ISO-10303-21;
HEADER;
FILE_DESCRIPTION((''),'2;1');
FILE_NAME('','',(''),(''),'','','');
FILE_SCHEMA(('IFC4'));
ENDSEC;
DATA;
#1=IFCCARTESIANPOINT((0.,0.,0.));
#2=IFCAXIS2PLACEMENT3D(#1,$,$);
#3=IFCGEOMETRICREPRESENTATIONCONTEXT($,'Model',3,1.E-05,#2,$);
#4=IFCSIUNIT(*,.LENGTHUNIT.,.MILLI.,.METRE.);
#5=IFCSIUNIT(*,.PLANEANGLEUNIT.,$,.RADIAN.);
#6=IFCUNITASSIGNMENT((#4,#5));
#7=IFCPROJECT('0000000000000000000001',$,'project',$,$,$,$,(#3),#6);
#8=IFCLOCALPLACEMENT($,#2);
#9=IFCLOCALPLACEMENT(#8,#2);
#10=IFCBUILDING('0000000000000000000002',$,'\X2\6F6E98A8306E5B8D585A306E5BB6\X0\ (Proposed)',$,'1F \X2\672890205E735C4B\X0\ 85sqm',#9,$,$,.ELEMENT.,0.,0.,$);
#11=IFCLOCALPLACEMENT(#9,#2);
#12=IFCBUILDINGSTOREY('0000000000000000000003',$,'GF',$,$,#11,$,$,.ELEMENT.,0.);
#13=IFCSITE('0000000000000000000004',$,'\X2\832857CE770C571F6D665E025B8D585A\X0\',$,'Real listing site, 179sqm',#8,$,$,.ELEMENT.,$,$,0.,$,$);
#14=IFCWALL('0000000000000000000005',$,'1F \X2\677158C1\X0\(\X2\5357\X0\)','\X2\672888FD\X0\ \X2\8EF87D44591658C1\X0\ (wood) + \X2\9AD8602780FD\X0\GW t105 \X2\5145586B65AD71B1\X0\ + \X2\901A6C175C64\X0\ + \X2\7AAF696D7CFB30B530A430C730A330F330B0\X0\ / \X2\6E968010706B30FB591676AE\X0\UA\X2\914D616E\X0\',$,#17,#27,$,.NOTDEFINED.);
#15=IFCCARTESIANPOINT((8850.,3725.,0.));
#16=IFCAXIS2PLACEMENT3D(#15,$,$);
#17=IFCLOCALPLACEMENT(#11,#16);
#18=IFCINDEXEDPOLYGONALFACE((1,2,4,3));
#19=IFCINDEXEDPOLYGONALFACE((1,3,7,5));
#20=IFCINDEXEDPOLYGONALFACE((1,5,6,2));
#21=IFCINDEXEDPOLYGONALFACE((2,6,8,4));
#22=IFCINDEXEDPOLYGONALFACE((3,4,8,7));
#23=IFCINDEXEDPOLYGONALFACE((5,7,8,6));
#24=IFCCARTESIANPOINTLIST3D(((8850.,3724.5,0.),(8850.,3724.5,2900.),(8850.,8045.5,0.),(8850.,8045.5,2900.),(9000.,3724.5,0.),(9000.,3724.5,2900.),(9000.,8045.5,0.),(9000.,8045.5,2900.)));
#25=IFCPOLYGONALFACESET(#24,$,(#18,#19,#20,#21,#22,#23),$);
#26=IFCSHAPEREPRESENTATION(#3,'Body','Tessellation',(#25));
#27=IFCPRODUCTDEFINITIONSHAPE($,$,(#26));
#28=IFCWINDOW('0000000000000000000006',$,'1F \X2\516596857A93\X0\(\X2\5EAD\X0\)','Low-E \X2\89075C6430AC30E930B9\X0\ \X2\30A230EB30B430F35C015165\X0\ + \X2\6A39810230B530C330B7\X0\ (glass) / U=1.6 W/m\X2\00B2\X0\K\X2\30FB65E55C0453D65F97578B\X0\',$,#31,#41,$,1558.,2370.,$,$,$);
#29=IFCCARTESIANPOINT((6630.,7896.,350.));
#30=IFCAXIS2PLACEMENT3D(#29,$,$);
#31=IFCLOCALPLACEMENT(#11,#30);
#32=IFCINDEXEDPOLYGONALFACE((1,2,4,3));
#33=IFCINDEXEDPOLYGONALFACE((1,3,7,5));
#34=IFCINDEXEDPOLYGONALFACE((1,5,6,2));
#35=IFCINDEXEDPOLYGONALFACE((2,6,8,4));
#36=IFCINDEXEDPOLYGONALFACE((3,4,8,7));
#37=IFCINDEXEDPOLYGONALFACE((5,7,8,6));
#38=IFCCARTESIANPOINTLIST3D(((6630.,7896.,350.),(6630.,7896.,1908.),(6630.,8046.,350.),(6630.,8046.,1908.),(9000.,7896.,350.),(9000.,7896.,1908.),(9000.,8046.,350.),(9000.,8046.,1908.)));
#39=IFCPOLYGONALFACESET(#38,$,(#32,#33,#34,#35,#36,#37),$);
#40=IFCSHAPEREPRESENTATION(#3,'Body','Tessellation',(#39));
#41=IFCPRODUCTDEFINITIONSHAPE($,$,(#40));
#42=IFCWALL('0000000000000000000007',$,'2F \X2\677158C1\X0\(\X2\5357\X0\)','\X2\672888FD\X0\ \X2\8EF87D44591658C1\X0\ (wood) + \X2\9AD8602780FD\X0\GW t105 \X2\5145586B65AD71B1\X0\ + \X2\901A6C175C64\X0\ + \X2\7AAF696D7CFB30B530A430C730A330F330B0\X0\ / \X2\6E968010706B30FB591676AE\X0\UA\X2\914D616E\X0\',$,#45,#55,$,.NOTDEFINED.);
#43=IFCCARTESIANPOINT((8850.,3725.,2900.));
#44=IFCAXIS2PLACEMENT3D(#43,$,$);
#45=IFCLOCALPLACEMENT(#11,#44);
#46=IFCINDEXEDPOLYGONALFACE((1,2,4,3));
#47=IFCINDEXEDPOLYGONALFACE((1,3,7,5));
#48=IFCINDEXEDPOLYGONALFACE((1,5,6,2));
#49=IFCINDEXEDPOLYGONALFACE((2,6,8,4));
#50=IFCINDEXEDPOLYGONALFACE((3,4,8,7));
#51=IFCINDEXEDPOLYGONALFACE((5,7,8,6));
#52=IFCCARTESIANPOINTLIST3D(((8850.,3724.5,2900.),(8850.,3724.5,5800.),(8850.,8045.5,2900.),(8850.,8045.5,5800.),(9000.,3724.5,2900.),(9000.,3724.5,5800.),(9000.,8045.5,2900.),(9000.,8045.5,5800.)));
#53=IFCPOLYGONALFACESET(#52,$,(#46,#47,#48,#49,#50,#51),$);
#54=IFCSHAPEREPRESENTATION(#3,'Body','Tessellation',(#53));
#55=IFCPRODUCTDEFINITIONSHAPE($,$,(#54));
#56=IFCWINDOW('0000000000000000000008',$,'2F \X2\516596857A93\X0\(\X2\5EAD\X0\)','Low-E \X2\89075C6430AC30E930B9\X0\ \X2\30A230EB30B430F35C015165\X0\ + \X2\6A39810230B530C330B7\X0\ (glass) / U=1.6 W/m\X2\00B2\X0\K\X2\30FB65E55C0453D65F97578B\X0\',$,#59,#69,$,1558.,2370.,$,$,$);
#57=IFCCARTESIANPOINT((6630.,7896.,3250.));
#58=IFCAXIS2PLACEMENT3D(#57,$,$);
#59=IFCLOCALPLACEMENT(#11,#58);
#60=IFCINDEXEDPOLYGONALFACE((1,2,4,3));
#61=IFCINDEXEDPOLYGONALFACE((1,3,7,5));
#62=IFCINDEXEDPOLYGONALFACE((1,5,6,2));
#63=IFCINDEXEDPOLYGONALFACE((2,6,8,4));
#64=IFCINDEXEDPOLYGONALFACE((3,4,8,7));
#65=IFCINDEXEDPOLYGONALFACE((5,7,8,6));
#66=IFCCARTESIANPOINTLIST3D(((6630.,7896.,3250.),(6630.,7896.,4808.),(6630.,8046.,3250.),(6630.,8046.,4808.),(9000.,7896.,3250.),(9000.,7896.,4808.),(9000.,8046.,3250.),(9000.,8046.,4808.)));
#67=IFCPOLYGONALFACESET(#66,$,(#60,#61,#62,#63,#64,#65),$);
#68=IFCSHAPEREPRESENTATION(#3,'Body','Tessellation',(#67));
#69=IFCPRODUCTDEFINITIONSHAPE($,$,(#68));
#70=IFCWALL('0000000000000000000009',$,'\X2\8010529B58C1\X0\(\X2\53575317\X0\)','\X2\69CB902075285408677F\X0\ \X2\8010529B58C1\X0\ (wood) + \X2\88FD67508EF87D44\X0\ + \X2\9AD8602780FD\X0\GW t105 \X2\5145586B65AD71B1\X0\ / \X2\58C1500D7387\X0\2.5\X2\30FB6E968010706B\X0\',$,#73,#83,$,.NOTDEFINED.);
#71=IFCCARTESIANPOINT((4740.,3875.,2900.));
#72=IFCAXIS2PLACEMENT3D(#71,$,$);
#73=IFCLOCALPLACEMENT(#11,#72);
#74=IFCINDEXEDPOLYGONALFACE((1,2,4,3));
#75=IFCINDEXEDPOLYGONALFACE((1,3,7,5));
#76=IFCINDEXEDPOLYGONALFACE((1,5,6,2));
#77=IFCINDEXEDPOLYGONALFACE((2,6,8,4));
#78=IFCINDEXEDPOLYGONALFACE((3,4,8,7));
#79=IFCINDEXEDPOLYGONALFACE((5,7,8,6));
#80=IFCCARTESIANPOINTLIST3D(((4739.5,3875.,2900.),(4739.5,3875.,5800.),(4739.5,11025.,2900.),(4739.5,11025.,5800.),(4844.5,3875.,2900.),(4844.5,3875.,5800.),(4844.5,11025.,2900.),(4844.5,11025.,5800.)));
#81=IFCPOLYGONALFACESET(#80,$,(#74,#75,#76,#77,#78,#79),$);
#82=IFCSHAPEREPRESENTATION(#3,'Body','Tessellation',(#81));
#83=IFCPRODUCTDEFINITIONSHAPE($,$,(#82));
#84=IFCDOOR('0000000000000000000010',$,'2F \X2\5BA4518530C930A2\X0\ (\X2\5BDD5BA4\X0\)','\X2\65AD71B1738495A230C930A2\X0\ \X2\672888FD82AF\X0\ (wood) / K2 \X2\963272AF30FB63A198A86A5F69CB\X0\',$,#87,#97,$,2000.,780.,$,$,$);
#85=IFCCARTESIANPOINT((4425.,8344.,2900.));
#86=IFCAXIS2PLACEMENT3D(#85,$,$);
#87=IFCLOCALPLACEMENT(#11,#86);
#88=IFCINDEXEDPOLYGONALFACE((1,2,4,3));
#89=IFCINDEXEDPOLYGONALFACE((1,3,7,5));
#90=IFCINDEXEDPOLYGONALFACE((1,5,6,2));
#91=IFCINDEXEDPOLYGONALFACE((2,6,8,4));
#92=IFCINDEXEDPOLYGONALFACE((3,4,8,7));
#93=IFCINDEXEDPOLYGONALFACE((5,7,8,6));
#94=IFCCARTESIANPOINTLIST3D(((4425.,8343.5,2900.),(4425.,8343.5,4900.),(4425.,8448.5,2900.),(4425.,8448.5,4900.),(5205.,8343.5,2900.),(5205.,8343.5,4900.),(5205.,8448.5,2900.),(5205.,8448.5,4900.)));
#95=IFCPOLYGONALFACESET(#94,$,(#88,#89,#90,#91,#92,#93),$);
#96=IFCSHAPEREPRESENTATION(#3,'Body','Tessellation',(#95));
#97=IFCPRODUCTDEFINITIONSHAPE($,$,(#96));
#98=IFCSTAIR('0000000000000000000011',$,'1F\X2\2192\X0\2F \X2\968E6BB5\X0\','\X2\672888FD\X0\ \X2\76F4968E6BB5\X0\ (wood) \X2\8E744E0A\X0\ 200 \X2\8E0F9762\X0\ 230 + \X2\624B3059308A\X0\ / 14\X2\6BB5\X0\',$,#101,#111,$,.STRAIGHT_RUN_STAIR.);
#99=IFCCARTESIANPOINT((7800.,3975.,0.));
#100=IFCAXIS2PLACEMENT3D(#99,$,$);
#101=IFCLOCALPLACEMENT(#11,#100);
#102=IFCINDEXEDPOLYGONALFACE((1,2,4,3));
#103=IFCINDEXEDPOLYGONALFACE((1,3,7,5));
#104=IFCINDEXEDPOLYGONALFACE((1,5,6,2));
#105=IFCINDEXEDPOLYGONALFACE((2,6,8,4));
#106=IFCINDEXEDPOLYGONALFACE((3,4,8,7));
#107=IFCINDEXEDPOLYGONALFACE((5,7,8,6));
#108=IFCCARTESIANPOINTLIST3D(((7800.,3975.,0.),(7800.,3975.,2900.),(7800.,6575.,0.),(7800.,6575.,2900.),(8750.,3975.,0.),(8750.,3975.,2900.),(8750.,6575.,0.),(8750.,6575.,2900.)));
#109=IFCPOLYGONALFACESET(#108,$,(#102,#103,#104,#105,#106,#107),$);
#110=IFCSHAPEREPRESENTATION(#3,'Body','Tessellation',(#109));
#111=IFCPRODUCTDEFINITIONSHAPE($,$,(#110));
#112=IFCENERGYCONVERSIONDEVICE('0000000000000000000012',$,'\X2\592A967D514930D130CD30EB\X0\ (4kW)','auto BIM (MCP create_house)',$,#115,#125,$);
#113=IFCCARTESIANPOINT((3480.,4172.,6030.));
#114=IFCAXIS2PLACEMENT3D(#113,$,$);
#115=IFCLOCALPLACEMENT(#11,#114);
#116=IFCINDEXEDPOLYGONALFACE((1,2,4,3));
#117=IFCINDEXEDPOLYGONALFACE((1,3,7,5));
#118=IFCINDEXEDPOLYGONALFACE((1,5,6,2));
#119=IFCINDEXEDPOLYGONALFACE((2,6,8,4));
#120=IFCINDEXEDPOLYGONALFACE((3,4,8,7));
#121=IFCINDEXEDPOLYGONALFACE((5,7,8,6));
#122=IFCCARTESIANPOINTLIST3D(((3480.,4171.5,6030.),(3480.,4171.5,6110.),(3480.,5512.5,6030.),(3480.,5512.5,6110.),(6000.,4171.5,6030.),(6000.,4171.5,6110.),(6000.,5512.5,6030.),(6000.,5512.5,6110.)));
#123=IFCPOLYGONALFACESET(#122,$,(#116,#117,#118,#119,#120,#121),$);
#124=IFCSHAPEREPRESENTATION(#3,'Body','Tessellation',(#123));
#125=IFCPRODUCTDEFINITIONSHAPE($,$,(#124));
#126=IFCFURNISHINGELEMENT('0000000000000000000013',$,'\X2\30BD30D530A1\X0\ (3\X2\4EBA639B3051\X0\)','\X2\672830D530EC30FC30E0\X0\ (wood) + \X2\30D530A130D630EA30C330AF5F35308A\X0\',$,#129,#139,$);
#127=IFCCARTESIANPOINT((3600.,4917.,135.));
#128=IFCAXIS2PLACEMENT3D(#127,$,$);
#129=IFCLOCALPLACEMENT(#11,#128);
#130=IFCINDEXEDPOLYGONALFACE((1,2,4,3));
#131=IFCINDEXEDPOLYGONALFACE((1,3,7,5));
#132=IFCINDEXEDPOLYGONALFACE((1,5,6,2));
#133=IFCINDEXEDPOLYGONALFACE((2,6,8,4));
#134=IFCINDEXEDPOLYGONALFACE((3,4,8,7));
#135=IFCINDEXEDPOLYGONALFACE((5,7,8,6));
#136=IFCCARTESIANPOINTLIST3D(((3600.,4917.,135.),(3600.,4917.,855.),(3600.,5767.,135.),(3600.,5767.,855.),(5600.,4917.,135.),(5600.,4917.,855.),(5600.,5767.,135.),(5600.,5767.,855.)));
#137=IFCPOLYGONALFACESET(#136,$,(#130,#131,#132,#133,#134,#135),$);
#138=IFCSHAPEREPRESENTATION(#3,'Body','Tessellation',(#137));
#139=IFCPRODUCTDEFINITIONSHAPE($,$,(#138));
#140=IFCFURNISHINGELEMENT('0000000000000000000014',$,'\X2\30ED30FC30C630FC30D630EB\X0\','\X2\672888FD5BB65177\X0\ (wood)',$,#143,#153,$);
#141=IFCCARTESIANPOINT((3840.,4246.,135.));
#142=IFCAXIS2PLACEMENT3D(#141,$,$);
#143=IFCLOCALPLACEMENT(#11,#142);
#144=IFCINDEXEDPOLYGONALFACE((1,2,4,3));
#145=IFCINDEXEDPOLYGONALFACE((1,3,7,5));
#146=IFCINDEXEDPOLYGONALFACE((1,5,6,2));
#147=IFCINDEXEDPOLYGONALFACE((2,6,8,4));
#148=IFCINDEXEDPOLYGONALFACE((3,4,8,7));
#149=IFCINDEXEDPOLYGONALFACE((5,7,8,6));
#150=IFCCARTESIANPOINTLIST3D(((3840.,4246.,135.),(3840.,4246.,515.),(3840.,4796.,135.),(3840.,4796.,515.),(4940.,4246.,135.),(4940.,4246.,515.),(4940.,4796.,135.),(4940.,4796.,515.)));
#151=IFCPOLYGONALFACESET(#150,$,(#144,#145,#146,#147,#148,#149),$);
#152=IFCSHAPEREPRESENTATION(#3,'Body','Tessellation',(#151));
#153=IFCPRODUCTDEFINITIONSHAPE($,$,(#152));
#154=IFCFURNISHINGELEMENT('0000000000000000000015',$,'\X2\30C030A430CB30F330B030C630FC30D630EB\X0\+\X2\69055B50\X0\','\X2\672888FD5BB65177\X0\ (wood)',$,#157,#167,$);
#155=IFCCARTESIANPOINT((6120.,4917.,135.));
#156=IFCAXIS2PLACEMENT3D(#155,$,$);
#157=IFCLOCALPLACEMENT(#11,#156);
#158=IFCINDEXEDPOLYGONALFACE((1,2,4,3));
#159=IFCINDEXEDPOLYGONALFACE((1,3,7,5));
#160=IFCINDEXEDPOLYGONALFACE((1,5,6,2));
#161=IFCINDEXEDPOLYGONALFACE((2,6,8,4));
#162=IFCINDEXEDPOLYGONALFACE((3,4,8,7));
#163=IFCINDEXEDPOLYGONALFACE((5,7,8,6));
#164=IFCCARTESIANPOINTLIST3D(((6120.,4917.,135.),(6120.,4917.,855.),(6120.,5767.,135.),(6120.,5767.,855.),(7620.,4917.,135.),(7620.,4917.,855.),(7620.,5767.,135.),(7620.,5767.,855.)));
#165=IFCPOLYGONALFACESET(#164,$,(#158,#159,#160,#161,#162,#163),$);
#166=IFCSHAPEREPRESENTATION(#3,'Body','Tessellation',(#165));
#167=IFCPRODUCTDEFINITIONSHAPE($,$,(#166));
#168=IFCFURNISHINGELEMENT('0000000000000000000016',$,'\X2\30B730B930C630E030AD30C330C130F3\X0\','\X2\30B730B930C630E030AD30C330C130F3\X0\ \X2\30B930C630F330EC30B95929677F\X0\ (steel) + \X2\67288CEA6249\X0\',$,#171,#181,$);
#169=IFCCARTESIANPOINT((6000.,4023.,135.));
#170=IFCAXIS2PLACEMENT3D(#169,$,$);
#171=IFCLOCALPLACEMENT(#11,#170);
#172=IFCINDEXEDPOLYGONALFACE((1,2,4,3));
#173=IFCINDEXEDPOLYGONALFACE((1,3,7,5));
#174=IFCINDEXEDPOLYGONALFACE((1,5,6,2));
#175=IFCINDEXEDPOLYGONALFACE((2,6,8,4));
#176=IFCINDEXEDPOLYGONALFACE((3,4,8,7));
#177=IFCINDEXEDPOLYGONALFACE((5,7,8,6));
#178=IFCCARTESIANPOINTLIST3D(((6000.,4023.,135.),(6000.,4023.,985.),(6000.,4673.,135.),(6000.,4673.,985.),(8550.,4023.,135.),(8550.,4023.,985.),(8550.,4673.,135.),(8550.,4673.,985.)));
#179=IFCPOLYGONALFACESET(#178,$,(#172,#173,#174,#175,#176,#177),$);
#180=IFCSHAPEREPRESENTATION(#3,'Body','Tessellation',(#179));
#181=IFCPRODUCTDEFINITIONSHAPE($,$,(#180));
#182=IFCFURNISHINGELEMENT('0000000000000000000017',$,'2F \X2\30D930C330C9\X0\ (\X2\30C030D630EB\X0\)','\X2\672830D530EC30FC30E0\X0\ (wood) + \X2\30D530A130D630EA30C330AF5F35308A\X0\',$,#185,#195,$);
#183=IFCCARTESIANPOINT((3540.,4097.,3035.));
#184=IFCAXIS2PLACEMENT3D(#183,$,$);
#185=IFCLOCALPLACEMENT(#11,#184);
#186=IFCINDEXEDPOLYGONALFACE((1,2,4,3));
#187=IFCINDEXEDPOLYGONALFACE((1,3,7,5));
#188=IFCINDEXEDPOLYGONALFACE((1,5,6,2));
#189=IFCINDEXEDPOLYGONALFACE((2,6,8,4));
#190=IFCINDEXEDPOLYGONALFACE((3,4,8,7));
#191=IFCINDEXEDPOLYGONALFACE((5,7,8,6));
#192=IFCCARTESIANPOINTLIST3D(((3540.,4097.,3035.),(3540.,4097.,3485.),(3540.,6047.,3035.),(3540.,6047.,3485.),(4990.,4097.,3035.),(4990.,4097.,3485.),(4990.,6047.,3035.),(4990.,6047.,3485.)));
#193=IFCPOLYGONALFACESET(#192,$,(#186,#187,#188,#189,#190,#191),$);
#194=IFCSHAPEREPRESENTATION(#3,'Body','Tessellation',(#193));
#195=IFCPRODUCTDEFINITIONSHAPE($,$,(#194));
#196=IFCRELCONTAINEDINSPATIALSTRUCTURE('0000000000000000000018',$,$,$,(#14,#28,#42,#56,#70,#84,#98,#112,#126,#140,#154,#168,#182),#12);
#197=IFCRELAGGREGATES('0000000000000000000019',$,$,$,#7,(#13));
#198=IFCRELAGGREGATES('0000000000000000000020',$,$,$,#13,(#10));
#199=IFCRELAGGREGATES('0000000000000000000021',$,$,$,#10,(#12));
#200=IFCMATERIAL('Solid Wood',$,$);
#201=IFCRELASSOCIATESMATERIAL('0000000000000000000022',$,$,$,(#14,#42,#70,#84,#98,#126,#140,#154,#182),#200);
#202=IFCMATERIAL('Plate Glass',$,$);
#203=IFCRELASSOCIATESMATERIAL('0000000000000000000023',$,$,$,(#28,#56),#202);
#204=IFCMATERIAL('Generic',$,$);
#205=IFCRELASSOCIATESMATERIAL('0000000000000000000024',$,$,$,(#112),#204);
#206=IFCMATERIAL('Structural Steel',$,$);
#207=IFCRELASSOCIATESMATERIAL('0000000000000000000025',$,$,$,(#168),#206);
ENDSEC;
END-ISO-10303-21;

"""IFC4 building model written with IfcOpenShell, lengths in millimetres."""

from ifc_helpers import new_model, si_unit, frame, frame_2d, origin, place, context, project, spatial, rectangle, extrude, material, element, fill, save


model = new_model("IFC4")

# Units and contexts
model_context = context("Model", 3, precision=1e-05, world=origin())
ifc_project = project(units=[si_unit("LENGTHUNIT", "METRE", prefix="MILLI"), si_unit("PLANEANGLEUNIT", "RADIAN")], contexts=[model_context])

# Site, building, storey
site_placement = place(None, origin())
site = spatial("IfcSite", under=ifc_project, at=site_placement, Name="茨城県土浦市宍塚", ObjectType="Real listing site, 179sqm", CompositionType="ELEMENT", RefElevation=0.0)
building_placement = place(site_placement, origin())
building = spatial("IfcBuilding", under=site, at=building_placement, Name="潮風の宍塚の家 (Proposed)", ObjectType="1F 木造平屋 85sqm", CompositionType="ELEMENT", ElevationOfRefHeight=0.0, ElevationOfTerrain=0.0)
storey_placement = place(building_placement, origin())
storey = spatial("IfcBuildingStorey", under=building, at=storey_placement, Name="GF", CompositionType="ELEMENT", Elevation=0.0)

# Wall, opening, window
ifc_material_1 = material(Name="Solid Wood")
wall_1_placement = place(storey_placement, frame((8850.0, 3725.0, 0.0)))
wall_1 = element("IfcWall", 1, at=wall_1_placement, inside=storey, material=ifc_material_1, Name="1F 東壁(南)", Description="木製 軸組外壁 (wood) + 高性能GW t105 充填断熱 + 通気層 + 窯業系サイディング / 準耐火・外皮UA配慮", PredefinedType="NOTDEFINED", context=model_context, shape_type="SweptSolid", body=[
    extrude(rectangle(XDim=150.0, YDim=4321.0, at=frame_2d((75.0, 2160.0))), frame((8850.0, 3725.0, 0.0)), (0.0, 0.0, 1.0), 2900.0),
])
opening_1_placement = place(storey_placement, frame((6630.0, 7896.0, 350.0)))
opening_1 = element("IfcOpeningElement", 2, at=opening_1_placement, cuts=wall_1, PredefinedType="NOTDEFINED", context=model_context, shape_type="SweptSolid", body=[
    extrude(rectangle(XDim=2370.0, YDim=150.0, at=frame_2d((1185.0, 75.0))), frame((6630.0, 7896.0, 350.0)), (0.0, 0.0, 1.0), 1558.0),
])
ifc_material_2 = material(Name="Plate Glass")
window_1_placement = place(storey_placement, frame((6630.0, 7896.0, 350.0)))
window_1 = element("IfcWindow", 3, at=window_1_placement, inside=storey, material=ifc_material_2, Name="1F 入隅窓(庭)", Description="Low-E 複層ガラス アルゴン封入 + 樹脂サッシ (glass) / U=1.6 W/m²K・日射取得型", OverallHeight=1558.0, OverallWidth=2370.0, context=model_context, shape_type="SweptSolid", body=[
    extrude(rectangle(XDim=2370.0, YDim=150.0, at=frame_2d((1185.0, 75.0))), frame((6630.0, 7896.0, 350.0)), (0.0, 0.0, 1.0), 1558.0),
])
fill(opening_1, window_1)

# Wall, opening, window
wall_2_placement = place(storey_placement, frame((8850.0, 3725.0, 2900.0)))
wall_2 = element("IfcWall", 4, at=wall_2_placement, inside=storey, material=ifc_material_1, Name="2F 東壁(南)", Description="木製 軸組外壁 (wood) + 高性能GW t105 充填断熱 + 通気層 + 窯業系サイディング / 準耐火・外皮UA配慮", PredefinedType="NOTDEFINED", context=model_context, shape_type="SweptSolid", body=[
    extrude(rectangle(XDim=150.0, YDim=4321.0, at=frame_2d((75.0, 2160.0))), frame((8850.0, 3725.0, 2900.0)), (0.0, 0.0, 1.0), 2900.0),
])
opening_2_placement = place(storey_placement, frame((6630.0, 7896.0, 3250.0)))
opening_2 = element("IfcOpeningElement", 5, at=opening_2_placement, cuts=wall_2, PredefinedType="NOTDEFINED", context=model_context, shape_type="SweptSolid", body=[
    extrude(rectangle(XDim=2370.0, YDim=150.0, at=frame_2d((1185.0, 75.0))), frame((6630.0, 7896.0, 3250.0)), (0.0, 0.0, 1.0), 1558.0),
])
window_2_placement = place(storey_placement, frame((6630.0, 7896.0, 3250.0)))
window_2 = element("IfcWindow", 6, at=window_2_placement, inside=storey, material=ifc_material_2, Name="2F 入隅窓(庭)", Description="Low-E 複層ガラス アルゴン封入 + 樹脂サッシ (glass) / U=1.6 W/m²K・日射取得型", OverallHeight=1558.0, OverallWidth=2370.0, context=model_context, shape_type="SweptSolid", body=[
    extrude(rectangle(XDim=2370.0, YDim=150.0, at=frame_2d((1185.0, 75.0))), frame((6630.0, 7896.0, 3250.0)), (0.0, 0.0, 1.0), 1558.0),
])
fill(opening_2, window_2)

# Wall, opening, door
wall_3_placement = place(storey_placement, frame((4740.0, 3875.0, 2900.0)))
wall_3 = element("IfcWall", 7, at=wall_3_placement, inside=storey, material=ifc_material_1, Name="耐力壁(南北)", Description="構造用合板 耐力壁 (wood) + 製材軸組 + 高性能GW t105 充填断熱 / 壁倍率2.5・準耐火", PredefinedType="NOTDEFINED", context=model_context, shape_type="SweptSolid", body=[
    extrude(rectangle(XDim=105.0, YDim=7150.0, at=frame_2d((52.0, 3575.0))), frame((4740.0, 3875.0, 2900.0)), (0.0, 0.0, 1.0), 2900.0),
])
opening_3_placement = place(storey_placement, frame((4425.0, 8344.0, 2900.0)))
opening_3 = element("IfcOpeningElement", 8, at=opening_3_placement, cuts=wall_3, PredefinedType="NOTDEFINED", context=model_context, shape_type="SweptSolid", body=[
    extrude(rectangle(XDim=780.0, YDim=105.0, at=frame_2d((390.0, 52.0))), frame((4425.0, 8344.0, 2900.0)), (0.0, 0.0, 1.0), 2000.0),
])
door_1_placement = place(storey_placement, frame((4425.0, 8344.0, 2900.0)))
door_1 = element("IfcDoor", 9, at=door_1_placement, inside=storey, material=ifc_material_1, Name="2F 室内ドア (寝室)", Description="断熱玄関ドア 木製芯 (wood) / K2 防犯・採風機構", OverallHeight=2000.0, OverallWidth=780.0, context=model_context, shape_type="SweptSolid", body=[
    extrude(rectangle(XDim=780.0, YDim=105.0, at=frame_2d((390.0, 52.0))), frame((4425.0, 8344.0, 2900.0)), (0.0, 0.0, 1.0), 2000.0),
])
fill(opening_3, door_1)

# Stair
stair_placement = place(storey_placement, frame((7800.0, 3975.0, 0.0)))
element("IfcStair", 10, at=stair_placement, inside=storey, material=ifc_material_1, Name="1F→2F 階段", Description="木製 直階段 (wood) 蹴上 200 踏面 230 + 手すり / 14段", PredefinedType="STRAIGHT_RUN_STAIR", context=model_context, shape_type="SweptSolid", body=[
    extrude(rectangle(XDim=950.0, YDim=2600.0, at=frame_2d((475.0, 1300.0))), frame((7800.0, 3975.0, 0.0)), (0.0, 0.0, 1.0), 2900.0),
])

# Energy conversion device
ifc_material_3 = material(Name="Generic")
energy_conversion_device_placement = place(storey_placement, frame((3480.0, 4172.0, 6030.0)))
element("IfcEnergyConversionDevice", 11, at=energy_conversion_device_placement, inside=storey, material=ifc_material_3, Name="太陽光パネル (4kW)", Description="auto BIM (MCP create_house)", context=model_context, shape_type="SweptSolid", body=[
    extrude(rectangle(XDim=2520.0, YDim=1341.0, at=frame_2d((1260.0, 670.0))), frame((3480.0, 4172.0, 6030.0)), (0.0, 0.0, 1.0), 80.0),
])

# Furnishing elements
furnishing_1_placement = place(storey_placement, frame((3600.0, 4917.0, 135.0)))
element("IfcFurnishingElement", 12, at=furnishing_1_placement, inside=storey, material=ifc_material_1, Name="ソファ (3人掛け)", Description="木フレーム (wood) + ファブリック張り", context=model_context, shape_type="SweptSolid", body=[
    extrude(rectangle(XDim=2000.0, YDim=850.0, at=frame_2d((1000.0, 425.0))), frame((3600.0, 4917.0, 135.0)), (0.0, 0.0, 1.0), 720.0),
])
furnishing_2_placement = place(storey_placement, frame((3840.0, 4246.0, 135.0)))
element("IfcFurnishingElement", 13, at=furnishing_2_placement, inside=storey, material=ifc_material_1, Name="ローテーブル", Description="木製家具 (wood)", context=model_context, shape_type="SweptSolid", body=[
    extrude(rectangle(XDim=1100.0, YDim=550.0, at=frame_2d((550.0, 275.0))), frame((3840.0, 4246.0, 135.0)), (0.0, 0.0, 1.0), 380.0),
])
furnishing_3_placement = place(storey_placement, frame((6120.0, 4917.0, 135.0)))
element("IfcFurnishingElement", 14, at=furnishing_3_placement, inside=storey, material=ifc_material_1, Name="ダイニングテーブル+椅子", Description="木製家具 (wood)", context=model_context, shape_type="SweptSolid", body=[
    extrude(rectangle(XDim=1500.0, YDim=850.0, at=frame_2d((750.0, 425.0))), frame((6120.0, 4917.0, 135.0)), (0.0, 0.0, 1.0), 720.0),
])
ifc_material_4 = material(Name="Structural Steel")
furnishing_4_placement = place(storey_placement, frame((6000.0, 4023.0, 135.0)))
element("IfcFurnishingElement", 15, at=furnishing_4_placement, inside=storey, material=ifc_material_4, Name="システムキッチン", Description="システムキッチン ステンレス天板 (steel) + 木質扉", context=model_context, shape_type="SweptSolid", body=[
    extrude(rectangle(XDim=2550.0, YDim=650.0, at=frame_2d((1275.0, 325.0))), frame((6000.0, 4023.0, 135.0)), (0.0, 0.0, 1.0), 850.0),
])
furnishing_5_placement = place(storey_placement, frame((3540.0, 4097.0, 3035.0)))
element("IfcFurnishingElement", 16, at=furnishing_5_placement, inside=storey, material=ifc_material_1, Name="2F ベッド (ダブル)", Description="木フレーム (wood) + ファブリック張り", context=model_context, shape_type="SweptSolid", body=[
    extrude(rectangle(XDim=1450.0, YDim=1950.0, at=frame_2d((725.0, 975.0))), frame((3540.0, 4097.0, 3035.0)), (0.0, 0.0, 1.0), 450.0),
])

save(model, "model.ifc")
